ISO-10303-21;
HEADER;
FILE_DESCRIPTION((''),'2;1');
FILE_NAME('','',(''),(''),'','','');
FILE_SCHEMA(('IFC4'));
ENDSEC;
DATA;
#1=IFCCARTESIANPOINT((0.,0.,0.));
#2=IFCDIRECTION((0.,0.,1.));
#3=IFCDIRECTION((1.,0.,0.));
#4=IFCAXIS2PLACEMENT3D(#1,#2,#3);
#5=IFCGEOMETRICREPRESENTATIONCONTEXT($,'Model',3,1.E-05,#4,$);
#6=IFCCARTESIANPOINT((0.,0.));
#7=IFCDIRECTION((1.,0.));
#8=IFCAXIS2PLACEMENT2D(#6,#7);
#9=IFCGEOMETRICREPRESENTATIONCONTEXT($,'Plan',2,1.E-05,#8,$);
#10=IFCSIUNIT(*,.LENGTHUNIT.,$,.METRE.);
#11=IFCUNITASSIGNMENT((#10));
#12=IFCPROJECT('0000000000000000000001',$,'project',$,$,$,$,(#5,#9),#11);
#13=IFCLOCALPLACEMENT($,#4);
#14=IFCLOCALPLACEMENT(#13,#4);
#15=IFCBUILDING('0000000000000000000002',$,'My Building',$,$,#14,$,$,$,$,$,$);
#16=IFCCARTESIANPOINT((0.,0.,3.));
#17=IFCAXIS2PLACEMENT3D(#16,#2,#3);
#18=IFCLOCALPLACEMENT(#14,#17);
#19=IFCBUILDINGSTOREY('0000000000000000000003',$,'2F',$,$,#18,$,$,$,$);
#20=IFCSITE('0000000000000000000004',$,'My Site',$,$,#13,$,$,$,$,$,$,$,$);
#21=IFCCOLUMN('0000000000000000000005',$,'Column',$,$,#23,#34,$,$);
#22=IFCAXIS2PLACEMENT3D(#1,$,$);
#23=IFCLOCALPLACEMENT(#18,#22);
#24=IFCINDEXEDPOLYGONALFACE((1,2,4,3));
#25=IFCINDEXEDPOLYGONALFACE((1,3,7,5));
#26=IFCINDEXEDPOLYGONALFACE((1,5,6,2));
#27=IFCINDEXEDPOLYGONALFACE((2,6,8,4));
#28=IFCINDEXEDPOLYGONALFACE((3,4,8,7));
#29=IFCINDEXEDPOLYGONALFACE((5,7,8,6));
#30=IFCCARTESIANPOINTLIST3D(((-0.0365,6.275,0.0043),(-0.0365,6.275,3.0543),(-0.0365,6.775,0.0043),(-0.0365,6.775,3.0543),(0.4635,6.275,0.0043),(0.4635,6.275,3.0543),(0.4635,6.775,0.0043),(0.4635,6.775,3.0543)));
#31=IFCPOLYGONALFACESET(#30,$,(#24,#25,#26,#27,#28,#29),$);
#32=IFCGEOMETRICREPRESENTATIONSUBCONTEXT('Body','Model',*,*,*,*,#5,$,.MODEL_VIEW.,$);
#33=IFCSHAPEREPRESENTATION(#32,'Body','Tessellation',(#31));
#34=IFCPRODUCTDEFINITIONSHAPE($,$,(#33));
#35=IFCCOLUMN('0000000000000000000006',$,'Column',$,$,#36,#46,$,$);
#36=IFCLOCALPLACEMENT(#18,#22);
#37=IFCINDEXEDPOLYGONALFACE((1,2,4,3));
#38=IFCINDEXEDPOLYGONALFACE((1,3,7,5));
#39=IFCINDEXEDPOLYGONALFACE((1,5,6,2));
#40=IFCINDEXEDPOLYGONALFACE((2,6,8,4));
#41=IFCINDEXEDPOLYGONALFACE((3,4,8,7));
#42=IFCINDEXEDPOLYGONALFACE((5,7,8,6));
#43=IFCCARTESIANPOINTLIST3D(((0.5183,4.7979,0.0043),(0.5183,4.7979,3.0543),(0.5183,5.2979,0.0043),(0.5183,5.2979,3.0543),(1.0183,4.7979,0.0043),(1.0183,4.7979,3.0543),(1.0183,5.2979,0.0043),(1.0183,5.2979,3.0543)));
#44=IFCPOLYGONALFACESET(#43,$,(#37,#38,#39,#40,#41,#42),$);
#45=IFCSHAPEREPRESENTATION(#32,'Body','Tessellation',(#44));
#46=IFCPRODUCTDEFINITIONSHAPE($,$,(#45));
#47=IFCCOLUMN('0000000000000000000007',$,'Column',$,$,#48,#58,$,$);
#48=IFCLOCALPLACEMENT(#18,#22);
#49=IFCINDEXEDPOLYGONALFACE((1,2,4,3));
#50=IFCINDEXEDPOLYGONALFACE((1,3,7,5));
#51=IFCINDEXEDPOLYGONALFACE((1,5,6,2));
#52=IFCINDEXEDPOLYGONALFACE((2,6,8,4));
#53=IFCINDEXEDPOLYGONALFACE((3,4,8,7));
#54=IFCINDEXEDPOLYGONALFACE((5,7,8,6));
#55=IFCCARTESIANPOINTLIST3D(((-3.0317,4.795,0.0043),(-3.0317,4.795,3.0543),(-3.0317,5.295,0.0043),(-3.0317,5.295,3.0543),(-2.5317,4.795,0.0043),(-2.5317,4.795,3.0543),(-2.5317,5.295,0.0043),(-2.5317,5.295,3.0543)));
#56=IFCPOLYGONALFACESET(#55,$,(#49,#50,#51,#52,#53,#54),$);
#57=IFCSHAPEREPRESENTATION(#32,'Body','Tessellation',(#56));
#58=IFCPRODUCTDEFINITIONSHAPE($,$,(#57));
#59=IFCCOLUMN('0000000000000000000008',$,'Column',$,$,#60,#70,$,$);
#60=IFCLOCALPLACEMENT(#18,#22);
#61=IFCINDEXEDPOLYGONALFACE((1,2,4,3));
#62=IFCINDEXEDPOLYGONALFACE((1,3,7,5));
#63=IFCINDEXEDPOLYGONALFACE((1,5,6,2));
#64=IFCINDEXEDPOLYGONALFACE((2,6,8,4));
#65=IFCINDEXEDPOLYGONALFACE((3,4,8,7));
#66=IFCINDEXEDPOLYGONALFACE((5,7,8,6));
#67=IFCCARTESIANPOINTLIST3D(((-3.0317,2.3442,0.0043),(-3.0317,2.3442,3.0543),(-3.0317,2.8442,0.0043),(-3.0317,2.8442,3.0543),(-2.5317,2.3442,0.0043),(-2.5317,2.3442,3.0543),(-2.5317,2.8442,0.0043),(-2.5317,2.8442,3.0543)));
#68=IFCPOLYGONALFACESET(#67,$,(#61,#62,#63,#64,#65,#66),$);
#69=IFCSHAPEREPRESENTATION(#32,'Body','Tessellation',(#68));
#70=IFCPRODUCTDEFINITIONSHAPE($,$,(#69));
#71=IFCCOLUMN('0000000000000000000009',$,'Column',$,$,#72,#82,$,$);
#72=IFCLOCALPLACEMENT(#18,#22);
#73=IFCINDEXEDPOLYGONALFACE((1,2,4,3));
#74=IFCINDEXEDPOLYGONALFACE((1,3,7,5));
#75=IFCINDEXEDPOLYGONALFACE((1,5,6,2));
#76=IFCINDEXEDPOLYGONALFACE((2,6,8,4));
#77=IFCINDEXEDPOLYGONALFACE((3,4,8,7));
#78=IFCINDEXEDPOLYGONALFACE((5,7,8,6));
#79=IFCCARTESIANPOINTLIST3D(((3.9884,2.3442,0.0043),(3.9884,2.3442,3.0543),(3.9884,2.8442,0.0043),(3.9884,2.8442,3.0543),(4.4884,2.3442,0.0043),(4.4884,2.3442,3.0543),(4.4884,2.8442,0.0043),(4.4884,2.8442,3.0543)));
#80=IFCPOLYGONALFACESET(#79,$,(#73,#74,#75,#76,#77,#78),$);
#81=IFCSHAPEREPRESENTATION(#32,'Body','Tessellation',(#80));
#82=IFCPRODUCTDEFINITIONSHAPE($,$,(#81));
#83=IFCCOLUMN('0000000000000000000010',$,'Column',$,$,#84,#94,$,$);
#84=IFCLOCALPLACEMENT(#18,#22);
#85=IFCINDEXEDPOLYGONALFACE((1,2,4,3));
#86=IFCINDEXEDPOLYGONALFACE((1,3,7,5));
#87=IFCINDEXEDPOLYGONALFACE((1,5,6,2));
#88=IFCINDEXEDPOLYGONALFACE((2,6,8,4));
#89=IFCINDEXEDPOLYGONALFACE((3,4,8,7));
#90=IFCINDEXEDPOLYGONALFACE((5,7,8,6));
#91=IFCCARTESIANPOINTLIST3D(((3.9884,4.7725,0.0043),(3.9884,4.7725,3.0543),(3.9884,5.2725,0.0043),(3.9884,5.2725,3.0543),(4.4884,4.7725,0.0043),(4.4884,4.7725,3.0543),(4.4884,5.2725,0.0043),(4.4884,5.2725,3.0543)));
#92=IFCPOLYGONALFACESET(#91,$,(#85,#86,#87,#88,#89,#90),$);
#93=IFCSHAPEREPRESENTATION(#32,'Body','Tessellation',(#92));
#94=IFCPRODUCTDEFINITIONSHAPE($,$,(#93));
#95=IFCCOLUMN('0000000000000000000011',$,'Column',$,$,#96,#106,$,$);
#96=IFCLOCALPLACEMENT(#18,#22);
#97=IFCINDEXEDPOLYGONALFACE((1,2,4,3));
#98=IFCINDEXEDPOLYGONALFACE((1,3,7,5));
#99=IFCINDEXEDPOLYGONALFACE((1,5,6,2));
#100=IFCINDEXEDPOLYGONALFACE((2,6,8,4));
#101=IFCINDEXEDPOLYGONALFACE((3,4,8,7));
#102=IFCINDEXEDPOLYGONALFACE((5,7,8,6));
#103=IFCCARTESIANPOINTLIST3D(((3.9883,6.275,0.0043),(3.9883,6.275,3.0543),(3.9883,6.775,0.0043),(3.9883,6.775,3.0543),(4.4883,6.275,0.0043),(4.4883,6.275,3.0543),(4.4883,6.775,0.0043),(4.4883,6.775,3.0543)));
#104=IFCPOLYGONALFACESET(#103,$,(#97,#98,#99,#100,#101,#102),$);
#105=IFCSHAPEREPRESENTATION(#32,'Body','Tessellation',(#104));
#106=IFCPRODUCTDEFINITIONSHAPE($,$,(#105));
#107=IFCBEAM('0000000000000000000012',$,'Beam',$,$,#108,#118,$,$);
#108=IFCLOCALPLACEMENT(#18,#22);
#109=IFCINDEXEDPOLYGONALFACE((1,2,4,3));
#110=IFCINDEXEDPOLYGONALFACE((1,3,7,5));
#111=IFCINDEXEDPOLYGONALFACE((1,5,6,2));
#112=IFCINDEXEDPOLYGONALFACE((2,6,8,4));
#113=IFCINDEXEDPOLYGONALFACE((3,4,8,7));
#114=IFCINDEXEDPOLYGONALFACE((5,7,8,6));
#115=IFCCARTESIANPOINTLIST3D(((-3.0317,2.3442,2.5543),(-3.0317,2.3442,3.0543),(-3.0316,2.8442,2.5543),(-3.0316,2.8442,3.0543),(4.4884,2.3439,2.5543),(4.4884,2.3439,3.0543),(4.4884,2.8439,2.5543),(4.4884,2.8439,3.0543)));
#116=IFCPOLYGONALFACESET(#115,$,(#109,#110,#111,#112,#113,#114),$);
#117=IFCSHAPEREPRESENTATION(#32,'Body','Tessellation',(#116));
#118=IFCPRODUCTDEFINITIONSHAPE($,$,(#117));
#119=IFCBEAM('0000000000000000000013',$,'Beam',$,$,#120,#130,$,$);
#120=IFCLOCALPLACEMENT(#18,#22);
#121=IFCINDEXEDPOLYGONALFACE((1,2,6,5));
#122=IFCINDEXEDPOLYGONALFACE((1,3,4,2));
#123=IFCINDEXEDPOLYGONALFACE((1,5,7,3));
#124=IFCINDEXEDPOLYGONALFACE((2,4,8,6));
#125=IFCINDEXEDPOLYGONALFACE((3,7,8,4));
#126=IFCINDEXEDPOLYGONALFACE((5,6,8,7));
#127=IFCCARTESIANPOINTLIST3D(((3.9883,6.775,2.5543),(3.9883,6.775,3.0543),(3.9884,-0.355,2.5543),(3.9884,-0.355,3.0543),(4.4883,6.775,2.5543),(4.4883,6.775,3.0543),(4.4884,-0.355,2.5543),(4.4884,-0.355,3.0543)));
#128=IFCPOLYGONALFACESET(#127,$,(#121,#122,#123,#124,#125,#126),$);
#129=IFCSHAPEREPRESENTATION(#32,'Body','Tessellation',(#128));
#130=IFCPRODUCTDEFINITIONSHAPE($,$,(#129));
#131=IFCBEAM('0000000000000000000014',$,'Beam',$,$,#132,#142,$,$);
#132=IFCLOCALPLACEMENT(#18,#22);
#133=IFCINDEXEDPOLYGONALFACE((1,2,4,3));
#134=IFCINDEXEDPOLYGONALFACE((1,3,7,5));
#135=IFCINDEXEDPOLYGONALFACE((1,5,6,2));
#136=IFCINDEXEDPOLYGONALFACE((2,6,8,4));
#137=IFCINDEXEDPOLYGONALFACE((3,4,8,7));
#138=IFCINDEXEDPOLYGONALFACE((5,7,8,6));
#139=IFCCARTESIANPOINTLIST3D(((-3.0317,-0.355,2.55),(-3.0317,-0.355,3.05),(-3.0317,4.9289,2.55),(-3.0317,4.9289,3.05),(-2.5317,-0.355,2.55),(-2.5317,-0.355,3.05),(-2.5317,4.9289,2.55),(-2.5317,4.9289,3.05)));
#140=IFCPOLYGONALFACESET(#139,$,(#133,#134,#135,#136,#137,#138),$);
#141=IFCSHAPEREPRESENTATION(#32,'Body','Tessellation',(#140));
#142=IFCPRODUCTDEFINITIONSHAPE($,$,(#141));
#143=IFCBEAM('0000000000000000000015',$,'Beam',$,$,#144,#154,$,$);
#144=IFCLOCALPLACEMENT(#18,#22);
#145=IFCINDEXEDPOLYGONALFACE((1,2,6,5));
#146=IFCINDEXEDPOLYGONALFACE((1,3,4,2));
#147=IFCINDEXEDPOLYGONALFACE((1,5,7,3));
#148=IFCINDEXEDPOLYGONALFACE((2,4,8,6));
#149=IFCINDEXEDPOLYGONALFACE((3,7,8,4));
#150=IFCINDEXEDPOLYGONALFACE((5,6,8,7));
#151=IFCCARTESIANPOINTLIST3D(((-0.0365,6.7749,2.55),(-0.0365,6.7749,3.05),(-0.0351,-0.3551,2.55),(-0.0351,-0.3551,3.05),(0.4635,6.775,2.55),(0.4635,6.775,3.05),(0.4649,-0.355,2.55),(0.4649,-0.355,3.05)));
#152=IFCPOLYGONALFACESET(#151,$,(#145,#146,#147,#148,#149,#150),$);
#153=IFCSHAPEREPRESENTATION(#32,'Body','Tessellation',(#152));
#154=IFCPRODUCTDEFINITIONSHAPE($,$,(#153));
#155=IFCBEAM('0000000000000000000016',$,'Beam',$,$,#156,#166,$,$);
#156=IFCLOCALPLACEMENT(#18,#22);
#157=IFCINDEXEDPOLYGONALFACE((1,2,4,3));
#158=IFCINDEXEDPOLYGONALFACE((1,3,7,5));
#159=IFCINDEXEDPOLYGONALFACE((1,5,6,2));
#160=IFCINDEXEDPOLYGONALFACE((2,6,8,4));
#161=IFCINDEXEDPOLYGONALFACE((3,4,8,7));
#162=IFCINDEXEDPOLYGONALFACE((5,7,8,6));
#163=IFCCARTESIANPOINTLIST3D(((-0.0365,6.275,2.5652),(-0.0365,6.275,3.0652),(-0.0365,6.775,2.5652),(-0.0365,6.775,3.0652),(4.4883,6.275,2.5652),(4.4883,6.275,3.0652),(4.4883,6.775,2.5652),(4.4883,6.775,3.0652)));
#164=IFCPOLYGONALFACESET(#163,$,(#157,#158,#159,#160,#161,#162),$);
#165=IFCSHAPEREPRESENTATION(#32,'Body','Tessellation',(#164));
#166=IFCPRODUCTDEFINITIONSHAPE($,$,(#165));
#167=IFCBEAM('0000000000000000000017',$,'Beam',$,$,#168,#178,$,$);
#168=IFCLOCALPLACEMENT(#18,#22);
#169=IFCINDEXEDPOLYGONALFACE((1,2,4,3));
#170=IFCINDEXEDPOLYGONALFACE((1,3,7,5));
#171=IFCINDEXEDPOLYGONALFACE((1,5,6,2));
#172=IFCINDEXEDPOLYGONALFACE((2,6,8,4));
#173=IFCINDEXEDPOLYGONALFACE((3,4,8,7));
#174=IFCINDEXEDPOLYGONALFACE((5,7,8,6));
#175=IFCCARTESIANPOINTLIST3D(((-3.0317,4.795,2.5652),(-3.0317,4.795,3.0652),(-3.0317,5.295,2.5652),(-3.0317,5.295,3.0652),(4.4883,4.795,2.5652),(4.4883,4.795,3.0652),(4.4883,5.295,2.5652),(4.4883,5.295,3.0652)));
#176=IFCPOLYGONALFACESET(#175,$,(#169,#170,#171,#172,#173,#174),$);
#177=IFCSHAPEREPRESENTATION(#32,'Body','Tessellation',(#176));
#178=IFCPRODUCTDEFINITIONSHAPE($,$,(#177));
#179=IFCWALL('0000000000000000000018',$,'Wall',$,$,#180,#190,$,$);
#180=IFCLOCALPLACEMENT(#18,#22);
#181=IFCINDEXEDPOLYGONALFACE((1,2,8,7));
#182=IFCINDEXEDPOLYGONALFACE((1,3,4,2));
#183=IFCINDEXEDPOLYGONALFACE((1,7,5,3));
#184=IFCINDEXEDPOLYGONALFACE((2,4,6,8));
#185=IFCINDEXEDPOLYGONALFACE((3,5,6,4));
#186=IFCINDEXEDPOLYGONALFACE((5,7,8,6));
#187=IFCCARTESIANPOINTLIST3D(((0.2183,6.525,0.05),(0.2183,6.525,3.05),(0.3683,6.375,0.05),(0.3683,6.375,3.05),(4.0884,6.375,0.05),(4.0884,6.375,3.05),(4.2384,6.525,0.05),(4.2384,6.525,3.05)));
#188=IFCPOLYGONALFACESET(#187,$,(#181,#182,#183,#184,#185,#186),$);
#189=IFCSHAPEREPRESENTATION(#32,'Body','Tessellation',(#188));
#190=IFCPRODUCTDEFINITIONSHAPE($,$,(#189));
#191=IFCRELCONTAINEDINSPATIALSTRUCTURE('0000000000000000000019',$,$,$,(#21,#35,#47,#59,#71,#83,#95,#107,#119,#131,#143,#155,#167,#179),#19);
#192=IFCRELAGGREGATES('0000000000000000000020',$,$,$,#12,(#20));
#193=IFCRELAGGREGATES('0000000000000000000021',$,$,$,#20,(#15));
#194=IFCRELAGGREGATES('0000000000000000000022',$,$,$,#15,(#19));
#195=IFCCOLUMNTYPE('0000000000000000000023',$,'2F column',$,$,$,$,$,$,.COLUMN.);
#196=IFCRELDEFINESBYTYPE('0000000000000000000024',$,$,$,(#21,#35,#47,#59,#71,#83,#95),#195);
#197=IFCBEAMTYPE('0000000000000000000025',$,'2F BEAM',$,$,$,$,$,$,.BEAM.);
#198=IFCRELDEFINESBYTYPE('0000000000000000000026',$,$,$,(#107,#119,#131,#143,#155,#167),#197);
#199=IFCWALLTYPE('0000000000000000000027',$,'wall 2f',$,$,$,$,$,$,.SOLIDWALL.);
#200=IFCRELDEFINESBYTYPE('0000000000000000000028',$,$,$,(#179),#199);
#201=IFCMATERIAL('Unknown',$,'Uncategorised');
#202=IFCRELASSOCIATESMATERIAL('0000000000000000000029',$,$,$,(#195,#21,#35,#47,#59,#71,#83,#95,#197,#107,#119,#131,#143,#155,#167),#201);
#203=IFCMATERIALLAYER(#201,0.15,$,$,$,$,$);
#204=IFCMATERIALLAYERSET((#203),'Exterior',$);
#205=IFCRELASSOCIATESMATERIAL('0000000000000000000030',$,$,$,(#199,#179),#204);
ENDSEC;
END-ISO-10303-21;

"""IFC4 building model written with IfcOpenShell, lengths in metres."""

from ifc_helpers import new_model, si_unit, frame, origin_with_axes, origin_2d_with_axis, place, context, subcontext, project, spatial, line, indexed_curve, rectangle, outline, extrude, material, layer, layer_set, layer_usage, material_profile, profile_set, profile_usage, type_object, element, save


model = new_model("IFC4")

# Units and contexts
model_context = context("Model", 3, precision=1e-05, world=origin_with_axes())
plan_context = context("Plan", 2, precision=1e-05, world=origin_2d_with_axis())
body_context_1 = subcontext(model_context, "Body", "Model", "MODEL_VIEW")
ifc_project = project(units=[si_unit("LENGTHUNIT", "METRE")], contexts=[model_context, plan_context])

# Site, building, storey
site_placement = place(None, origin_with_axes())
site = spatial("IfcSite", under=ifc_project, at=site_placement, Name="My Site")
building_placement = place(site_placement, origin_with_axes())
building = spatial("IfcBuilding", under=site, at=building_placement, Name="My Building")
storey_placement = place(building_placement, frame((0.0, 0.0, 3.0), z_axis=(0.0, 0.0, 1.0), x_axis=(1.0, 0.0, 0.0)))
storey = spatial("IfcBuildingStorey", under=building, at=storey_placement, Name="2F")

# Columns
ifc_material = material(Name="Unknown", Category="Uncategorised")
ifc_material_profile_1 = material_profile(ifc_material, rectangle(XDim=0.5, YDim=0.5))
ifc_profile_set_1 = profile_set([ifc_material_profile_1])
ifc_profile_usage_1 = profile_usage(ifc_profile_set_1, cardinal=5)
column_type = type_object("IfcColumnType", Name="2F column", PredefinedType="COLUMN", material=ifc_profile_set_1)
column_1_placement = place(storey_placement, frame((0.2135, 6.525, 0.0043), z_axis=(0.0, 0.0, 1.0), x_axis=(1.0, 0.0, 0.0)))
element("IfcColumn", 1, at=column_1_placement, inside=storey, type_object=column_type, material=ifc_profile_usage_1, Name="Column", context=body_context_1, shape_type="SweptSolid", body=[
    extrude(rectangle(XDim=0.5, YDim=0.5), origin_with_axes(), (0.0, 0.0, 1.0), 3.05),
])
ifc_profile_usage_2 = profile_usage(ifc_profile_set_1, cardinal=5)
column_2_placement = place(storey_placement, frame((0.7683, 5.0479, 0.0043), z_axis=(0.0, 0.0, 1.0), x_axis=(1.0, 0.0, 0.0)))
element("IfcColumn", 2, at=column_2_placement, inside=storey, type_object=column_type, material=ifc_profile_usage_2, Name="Column", context=body_context_1, shape_type="SweptSolid", body=[
    extrude(rectangle(XDim=0.5, YDim=0.5), origin_with_axes(), (0.0, 0.0, 1.0), 3.05),
])
ifc_profile_usage_3 = profile_usage(ifc_profile_set_1, cardinal=5)
column_3_placement = place(storey_placement, frame((-2.7817, 5.045, 0.0043), z_axis=(0.0, 0.0, 1.0), x_axis=(1.0, 0.0, 0.0)))
element("IfcColumn", 3, at=column_3_placement, inside=storey, type_object=column_type, material=ifc_profile_usage_3, Name="Column", context=body_context_1, shape_type="SweptSolid", body=[
    extrude(rectangle(XDim=0.5, YDim=0.5), origin_with_axes(), (0.0, 0.0, 1.0), 3.05),
])
ifc_profile_usage_4 = profile_usage(ifc_profile_set_1, cardinal=5)
column_4_placement = place(storey_placement, frame((-2.7817, 2.5942, 0.0043), z_axis=(0.0, 0.0, 1.0), x_axis=(1.0, 0.0, 0.0)))
element("IfcColumn", 4, at=column_4_placement, inside=storey, type_object=column_type, material=ifc_profile_usage_4, Name="Column", context=body_context_1, shape_type="SweptSolid", body=[
    extrude(rectangle(XDim=0.5, YDim=0.5), origin_with_axes(), (0.0, 0.0, 1.0), 3.05),
])
ifc_profile_usage_5 = profile_usage(ifc_profile_set_1, cardinal=5)
column_5_placement = place(storey_placement, frame((4.2384, 2.5942, 0.0043), z_axis=(0.0, 0.0, 1.0), x_axis=(1.0, 0.0, 0.0)))
element("IfcColumn", 5, at=column_5_placement, inside=storey, type_object=column_type, material=ifc_profile_usage_5, Name="Column", context=body_context_1, shape_type="SweptSolid", body=[
    extrude(rectangle(XDim=0.5, YDim=0.5), origin_with_axes(), (0.0, 0.0, 1.0), 3.05),
])
ifc_profile_usage_6 = profile_usage(ifc_profile_set_1, cardinal=5)
column_6_placement = place(storey_placement, frame((4.2384, 5.0225, 0.0043), z_axis=(0.0, 0.0, 1.0), x_axis=(1.0, 0.0, 0.0)))
element("IfcColumn", 6, at=column_6_placement, inside=storey, type_object=column_type, material=ifc_profile_usage_6, Name="Column", context=body_context_1, shape_type="SweptSolid", body=[
    extrude(rectangle(XDim=0.5, YDim=0.5), origin_with_axes(), (0.0, 0.0, 1.0), 3.05),
])
ifc_profile_usage_7 = profile_usage(ifc_profile_set_1, cardinal=5)
column_7_placement = place(storey_placement, frame((4.2383, 6.525, 0.0043), z_axis=(0.0, 0.0, 1.0), x_axis=(1.0, 0.0, 0.0)))
element("IfcColumn", 7, at=column_7_placement, inside=storey, type_object=column_type, material=ifc_profile_usage_7, Name="Column", context=body_context_1, shape_type="SweptSolid", body=[
    extrude(rectangle(XDim=0.5, YDim=0.5), origin_with_axes(), (0.0, 0.0, 1.0), 3.05),
])

# Beams
ifc_material_profile_2 = material_profile(ifc_material, rectangle(XDim=0.5, YDim=0.5))
ifc_profile_set_2 = profile_set([ifc_material_profile_2])
ifc_profile_usage_8 = profile_usage(ifc_profile_set_2, cardinal=5)
beam_type = type_object("IfcBeamType", Name="2F BEAM", PredefinedType="BEAM", material=ifc_profile_set_2)
beam_1_placement = place(storey_placement, frame((-3.0316, 2.5942, 2.8043), z_axis=(1.0, -0.000042, 0.0), x_axis=(0.000042, 1.0, 0.0)))
element("IfcBeam", 8, at=beam_1_placement, inside=storey, type_object=beam_type, material=ifc_profile_usage_8, Name="Beam", context=body_context_1, shape_type="SweptSolid", body=[
    extrude(rectangle(XDim=0.5, YDim=0.5), origin_with_axes(), (0.0, 0.0, 1.0), 7.52),
])
ifc_profile_usage_9 = profile_usage(ifc_profile_set_2, cardinal=5)
beam_2_placement = place(storey_placement, frame((4.2383, 6.775, 2.8043), z_axis=(0.0, -1.0, 0.0), x_axis=(1.0, 0.0, 0.0)))
element("IfcBeam", 9, at=beam_2_placement, inside=storey, type_object=beam_type, material=ifc_profile_usage_9, Name="Beam", context=body_context_1, shape_type="SweptSolid", body=[
    extrude(rectangle(XDim=0.5, YDim=0.5), origin_with_axes(), (0.0, 0.0, 1.0), 7.13),
])
ifc_profile_usage_10 = profile_usage(ifc_profile_set_2, cardinal=5)
beam_3_placement = place(storey_placement, frame((-2.7817, 4.9289, 2.8), z_axis=(0.0, -1.0, 0.0), x_axis=(1.0, 0.0, 0.0)))
element("IfcBeam", 10, at=beam_3_placement, inside=storey, type_object=beam_type, material=ifc_profile_usage_10, Name="Beam", context=body_context_1, shape_type="SweptSolid", body=[
    extrude(rectangle(XDim=0.5, YDim=0.5), origin_with_axes(), (0.0, 0.0, 1.0), 5.2839),
])
ifc_profile_usage_11 = profile_usage(ifc_profile_set_2, cardinal=5)
beam_4_placement = place(storey_placement, frame((0.2135, 6.775, 2.8), z_axis=(0.000198, -1.0, 0.0), x_axis=(1.0, 0.000198, 0.0)))
element("IfcBeam", 11, at=beam_4_placement, inside=storey, type_object=beam_type, material=ifc_profile_usage_11, Name="Beam", context=body_context_1, shape_type="SweptSolid", body=[
    extrude(rectangle(XDim=0.5, YDim=0.5), origin_with_axes(), (0.0, 0.0, 1.0), 7.13),
])
ifc_profile_usage_12 = profile_usage(ifc_profile_set_2, cardinal=5)
beam_5_placement = place(storey_placement, frame((4.4883, 6.525, 2.8152), z_axis=(-1.0, 0.0, 0.0), x_axis=(0.0, -1.0, 0.0)))
element("IfcBeam", 12, at=beam_5_placement, inside=storey, type_object=beam_type, material=ifc_profile_usage_12, Name="Beam", context=body_context_1, shape_type="SweptSolid", body=[
    extrude(rectangle(XDim=0.5, YDim=0.5), origin_with_axes(), (0.0, 0.0, 1.0), 4.5249),
])
ifc_profile_usage_13 = profile_usage(ifc_profile_set_2, cardinal=5)
beam_6_placement = place(storey_placement, frame((-3.0317, 5.045, 2.8152), z_axis=(1.0, -0.000001, 0.000001), x_axis=(0.000001, 1.0, 0.0)))
element("IfcBeam", 13, at=beam_6_placement, inside=storey, type_object=beam_type, material=ifc_profile_usage_13, Name="Beam", context=body_context_1, shape_type="SweptSolid", body=[
    extrude(rectangle(XDim=0.5, YDim=0.5), origin_with_axes(), (0.0, 0.0, 1.0), 7.5199),
])

# Wall
ifc_layer_1 = layer(ifc_material, 0.15)
ifc_layer_set_1 = layer_set([ifc_layer_1], Name="Exterior")
ifc_layer_usage_1 = layer_usage(ifc_layer_set_1, "AXIS2", "POSITIVE", 0.0)
wall_type_1 = type_object("IfcWallType", Name="wall 2f", PredefinedType="SOLIDWALL", material=ifc_layer_set_1)
wall_1_placement = place(storey_placement, frame((4.2384, 6.525, 0.05), z_axis=(0.0, 0.0, 1.0), x_axis=(-1.0, 0.0, 0.0)))
element("IfcWall", 14, at=wall_1_placement, inside=storey, type_object=wall_type_1, material=ifc_layer_usage_1, Name="Wall", context=body_context_1, shape_type="SweptSolid", body=[
    extrude(outline(indexed_curve([(0.0, 0.0), (0.15, 0.15), (3.87, 0.15), (4.02, 0.0)], segments=[line(1, 2, 3, 4, 1)])), origin_with_axes(), (0.0, 0.0, 1.0), 3.0),
])

save(model, "model.ifc")
